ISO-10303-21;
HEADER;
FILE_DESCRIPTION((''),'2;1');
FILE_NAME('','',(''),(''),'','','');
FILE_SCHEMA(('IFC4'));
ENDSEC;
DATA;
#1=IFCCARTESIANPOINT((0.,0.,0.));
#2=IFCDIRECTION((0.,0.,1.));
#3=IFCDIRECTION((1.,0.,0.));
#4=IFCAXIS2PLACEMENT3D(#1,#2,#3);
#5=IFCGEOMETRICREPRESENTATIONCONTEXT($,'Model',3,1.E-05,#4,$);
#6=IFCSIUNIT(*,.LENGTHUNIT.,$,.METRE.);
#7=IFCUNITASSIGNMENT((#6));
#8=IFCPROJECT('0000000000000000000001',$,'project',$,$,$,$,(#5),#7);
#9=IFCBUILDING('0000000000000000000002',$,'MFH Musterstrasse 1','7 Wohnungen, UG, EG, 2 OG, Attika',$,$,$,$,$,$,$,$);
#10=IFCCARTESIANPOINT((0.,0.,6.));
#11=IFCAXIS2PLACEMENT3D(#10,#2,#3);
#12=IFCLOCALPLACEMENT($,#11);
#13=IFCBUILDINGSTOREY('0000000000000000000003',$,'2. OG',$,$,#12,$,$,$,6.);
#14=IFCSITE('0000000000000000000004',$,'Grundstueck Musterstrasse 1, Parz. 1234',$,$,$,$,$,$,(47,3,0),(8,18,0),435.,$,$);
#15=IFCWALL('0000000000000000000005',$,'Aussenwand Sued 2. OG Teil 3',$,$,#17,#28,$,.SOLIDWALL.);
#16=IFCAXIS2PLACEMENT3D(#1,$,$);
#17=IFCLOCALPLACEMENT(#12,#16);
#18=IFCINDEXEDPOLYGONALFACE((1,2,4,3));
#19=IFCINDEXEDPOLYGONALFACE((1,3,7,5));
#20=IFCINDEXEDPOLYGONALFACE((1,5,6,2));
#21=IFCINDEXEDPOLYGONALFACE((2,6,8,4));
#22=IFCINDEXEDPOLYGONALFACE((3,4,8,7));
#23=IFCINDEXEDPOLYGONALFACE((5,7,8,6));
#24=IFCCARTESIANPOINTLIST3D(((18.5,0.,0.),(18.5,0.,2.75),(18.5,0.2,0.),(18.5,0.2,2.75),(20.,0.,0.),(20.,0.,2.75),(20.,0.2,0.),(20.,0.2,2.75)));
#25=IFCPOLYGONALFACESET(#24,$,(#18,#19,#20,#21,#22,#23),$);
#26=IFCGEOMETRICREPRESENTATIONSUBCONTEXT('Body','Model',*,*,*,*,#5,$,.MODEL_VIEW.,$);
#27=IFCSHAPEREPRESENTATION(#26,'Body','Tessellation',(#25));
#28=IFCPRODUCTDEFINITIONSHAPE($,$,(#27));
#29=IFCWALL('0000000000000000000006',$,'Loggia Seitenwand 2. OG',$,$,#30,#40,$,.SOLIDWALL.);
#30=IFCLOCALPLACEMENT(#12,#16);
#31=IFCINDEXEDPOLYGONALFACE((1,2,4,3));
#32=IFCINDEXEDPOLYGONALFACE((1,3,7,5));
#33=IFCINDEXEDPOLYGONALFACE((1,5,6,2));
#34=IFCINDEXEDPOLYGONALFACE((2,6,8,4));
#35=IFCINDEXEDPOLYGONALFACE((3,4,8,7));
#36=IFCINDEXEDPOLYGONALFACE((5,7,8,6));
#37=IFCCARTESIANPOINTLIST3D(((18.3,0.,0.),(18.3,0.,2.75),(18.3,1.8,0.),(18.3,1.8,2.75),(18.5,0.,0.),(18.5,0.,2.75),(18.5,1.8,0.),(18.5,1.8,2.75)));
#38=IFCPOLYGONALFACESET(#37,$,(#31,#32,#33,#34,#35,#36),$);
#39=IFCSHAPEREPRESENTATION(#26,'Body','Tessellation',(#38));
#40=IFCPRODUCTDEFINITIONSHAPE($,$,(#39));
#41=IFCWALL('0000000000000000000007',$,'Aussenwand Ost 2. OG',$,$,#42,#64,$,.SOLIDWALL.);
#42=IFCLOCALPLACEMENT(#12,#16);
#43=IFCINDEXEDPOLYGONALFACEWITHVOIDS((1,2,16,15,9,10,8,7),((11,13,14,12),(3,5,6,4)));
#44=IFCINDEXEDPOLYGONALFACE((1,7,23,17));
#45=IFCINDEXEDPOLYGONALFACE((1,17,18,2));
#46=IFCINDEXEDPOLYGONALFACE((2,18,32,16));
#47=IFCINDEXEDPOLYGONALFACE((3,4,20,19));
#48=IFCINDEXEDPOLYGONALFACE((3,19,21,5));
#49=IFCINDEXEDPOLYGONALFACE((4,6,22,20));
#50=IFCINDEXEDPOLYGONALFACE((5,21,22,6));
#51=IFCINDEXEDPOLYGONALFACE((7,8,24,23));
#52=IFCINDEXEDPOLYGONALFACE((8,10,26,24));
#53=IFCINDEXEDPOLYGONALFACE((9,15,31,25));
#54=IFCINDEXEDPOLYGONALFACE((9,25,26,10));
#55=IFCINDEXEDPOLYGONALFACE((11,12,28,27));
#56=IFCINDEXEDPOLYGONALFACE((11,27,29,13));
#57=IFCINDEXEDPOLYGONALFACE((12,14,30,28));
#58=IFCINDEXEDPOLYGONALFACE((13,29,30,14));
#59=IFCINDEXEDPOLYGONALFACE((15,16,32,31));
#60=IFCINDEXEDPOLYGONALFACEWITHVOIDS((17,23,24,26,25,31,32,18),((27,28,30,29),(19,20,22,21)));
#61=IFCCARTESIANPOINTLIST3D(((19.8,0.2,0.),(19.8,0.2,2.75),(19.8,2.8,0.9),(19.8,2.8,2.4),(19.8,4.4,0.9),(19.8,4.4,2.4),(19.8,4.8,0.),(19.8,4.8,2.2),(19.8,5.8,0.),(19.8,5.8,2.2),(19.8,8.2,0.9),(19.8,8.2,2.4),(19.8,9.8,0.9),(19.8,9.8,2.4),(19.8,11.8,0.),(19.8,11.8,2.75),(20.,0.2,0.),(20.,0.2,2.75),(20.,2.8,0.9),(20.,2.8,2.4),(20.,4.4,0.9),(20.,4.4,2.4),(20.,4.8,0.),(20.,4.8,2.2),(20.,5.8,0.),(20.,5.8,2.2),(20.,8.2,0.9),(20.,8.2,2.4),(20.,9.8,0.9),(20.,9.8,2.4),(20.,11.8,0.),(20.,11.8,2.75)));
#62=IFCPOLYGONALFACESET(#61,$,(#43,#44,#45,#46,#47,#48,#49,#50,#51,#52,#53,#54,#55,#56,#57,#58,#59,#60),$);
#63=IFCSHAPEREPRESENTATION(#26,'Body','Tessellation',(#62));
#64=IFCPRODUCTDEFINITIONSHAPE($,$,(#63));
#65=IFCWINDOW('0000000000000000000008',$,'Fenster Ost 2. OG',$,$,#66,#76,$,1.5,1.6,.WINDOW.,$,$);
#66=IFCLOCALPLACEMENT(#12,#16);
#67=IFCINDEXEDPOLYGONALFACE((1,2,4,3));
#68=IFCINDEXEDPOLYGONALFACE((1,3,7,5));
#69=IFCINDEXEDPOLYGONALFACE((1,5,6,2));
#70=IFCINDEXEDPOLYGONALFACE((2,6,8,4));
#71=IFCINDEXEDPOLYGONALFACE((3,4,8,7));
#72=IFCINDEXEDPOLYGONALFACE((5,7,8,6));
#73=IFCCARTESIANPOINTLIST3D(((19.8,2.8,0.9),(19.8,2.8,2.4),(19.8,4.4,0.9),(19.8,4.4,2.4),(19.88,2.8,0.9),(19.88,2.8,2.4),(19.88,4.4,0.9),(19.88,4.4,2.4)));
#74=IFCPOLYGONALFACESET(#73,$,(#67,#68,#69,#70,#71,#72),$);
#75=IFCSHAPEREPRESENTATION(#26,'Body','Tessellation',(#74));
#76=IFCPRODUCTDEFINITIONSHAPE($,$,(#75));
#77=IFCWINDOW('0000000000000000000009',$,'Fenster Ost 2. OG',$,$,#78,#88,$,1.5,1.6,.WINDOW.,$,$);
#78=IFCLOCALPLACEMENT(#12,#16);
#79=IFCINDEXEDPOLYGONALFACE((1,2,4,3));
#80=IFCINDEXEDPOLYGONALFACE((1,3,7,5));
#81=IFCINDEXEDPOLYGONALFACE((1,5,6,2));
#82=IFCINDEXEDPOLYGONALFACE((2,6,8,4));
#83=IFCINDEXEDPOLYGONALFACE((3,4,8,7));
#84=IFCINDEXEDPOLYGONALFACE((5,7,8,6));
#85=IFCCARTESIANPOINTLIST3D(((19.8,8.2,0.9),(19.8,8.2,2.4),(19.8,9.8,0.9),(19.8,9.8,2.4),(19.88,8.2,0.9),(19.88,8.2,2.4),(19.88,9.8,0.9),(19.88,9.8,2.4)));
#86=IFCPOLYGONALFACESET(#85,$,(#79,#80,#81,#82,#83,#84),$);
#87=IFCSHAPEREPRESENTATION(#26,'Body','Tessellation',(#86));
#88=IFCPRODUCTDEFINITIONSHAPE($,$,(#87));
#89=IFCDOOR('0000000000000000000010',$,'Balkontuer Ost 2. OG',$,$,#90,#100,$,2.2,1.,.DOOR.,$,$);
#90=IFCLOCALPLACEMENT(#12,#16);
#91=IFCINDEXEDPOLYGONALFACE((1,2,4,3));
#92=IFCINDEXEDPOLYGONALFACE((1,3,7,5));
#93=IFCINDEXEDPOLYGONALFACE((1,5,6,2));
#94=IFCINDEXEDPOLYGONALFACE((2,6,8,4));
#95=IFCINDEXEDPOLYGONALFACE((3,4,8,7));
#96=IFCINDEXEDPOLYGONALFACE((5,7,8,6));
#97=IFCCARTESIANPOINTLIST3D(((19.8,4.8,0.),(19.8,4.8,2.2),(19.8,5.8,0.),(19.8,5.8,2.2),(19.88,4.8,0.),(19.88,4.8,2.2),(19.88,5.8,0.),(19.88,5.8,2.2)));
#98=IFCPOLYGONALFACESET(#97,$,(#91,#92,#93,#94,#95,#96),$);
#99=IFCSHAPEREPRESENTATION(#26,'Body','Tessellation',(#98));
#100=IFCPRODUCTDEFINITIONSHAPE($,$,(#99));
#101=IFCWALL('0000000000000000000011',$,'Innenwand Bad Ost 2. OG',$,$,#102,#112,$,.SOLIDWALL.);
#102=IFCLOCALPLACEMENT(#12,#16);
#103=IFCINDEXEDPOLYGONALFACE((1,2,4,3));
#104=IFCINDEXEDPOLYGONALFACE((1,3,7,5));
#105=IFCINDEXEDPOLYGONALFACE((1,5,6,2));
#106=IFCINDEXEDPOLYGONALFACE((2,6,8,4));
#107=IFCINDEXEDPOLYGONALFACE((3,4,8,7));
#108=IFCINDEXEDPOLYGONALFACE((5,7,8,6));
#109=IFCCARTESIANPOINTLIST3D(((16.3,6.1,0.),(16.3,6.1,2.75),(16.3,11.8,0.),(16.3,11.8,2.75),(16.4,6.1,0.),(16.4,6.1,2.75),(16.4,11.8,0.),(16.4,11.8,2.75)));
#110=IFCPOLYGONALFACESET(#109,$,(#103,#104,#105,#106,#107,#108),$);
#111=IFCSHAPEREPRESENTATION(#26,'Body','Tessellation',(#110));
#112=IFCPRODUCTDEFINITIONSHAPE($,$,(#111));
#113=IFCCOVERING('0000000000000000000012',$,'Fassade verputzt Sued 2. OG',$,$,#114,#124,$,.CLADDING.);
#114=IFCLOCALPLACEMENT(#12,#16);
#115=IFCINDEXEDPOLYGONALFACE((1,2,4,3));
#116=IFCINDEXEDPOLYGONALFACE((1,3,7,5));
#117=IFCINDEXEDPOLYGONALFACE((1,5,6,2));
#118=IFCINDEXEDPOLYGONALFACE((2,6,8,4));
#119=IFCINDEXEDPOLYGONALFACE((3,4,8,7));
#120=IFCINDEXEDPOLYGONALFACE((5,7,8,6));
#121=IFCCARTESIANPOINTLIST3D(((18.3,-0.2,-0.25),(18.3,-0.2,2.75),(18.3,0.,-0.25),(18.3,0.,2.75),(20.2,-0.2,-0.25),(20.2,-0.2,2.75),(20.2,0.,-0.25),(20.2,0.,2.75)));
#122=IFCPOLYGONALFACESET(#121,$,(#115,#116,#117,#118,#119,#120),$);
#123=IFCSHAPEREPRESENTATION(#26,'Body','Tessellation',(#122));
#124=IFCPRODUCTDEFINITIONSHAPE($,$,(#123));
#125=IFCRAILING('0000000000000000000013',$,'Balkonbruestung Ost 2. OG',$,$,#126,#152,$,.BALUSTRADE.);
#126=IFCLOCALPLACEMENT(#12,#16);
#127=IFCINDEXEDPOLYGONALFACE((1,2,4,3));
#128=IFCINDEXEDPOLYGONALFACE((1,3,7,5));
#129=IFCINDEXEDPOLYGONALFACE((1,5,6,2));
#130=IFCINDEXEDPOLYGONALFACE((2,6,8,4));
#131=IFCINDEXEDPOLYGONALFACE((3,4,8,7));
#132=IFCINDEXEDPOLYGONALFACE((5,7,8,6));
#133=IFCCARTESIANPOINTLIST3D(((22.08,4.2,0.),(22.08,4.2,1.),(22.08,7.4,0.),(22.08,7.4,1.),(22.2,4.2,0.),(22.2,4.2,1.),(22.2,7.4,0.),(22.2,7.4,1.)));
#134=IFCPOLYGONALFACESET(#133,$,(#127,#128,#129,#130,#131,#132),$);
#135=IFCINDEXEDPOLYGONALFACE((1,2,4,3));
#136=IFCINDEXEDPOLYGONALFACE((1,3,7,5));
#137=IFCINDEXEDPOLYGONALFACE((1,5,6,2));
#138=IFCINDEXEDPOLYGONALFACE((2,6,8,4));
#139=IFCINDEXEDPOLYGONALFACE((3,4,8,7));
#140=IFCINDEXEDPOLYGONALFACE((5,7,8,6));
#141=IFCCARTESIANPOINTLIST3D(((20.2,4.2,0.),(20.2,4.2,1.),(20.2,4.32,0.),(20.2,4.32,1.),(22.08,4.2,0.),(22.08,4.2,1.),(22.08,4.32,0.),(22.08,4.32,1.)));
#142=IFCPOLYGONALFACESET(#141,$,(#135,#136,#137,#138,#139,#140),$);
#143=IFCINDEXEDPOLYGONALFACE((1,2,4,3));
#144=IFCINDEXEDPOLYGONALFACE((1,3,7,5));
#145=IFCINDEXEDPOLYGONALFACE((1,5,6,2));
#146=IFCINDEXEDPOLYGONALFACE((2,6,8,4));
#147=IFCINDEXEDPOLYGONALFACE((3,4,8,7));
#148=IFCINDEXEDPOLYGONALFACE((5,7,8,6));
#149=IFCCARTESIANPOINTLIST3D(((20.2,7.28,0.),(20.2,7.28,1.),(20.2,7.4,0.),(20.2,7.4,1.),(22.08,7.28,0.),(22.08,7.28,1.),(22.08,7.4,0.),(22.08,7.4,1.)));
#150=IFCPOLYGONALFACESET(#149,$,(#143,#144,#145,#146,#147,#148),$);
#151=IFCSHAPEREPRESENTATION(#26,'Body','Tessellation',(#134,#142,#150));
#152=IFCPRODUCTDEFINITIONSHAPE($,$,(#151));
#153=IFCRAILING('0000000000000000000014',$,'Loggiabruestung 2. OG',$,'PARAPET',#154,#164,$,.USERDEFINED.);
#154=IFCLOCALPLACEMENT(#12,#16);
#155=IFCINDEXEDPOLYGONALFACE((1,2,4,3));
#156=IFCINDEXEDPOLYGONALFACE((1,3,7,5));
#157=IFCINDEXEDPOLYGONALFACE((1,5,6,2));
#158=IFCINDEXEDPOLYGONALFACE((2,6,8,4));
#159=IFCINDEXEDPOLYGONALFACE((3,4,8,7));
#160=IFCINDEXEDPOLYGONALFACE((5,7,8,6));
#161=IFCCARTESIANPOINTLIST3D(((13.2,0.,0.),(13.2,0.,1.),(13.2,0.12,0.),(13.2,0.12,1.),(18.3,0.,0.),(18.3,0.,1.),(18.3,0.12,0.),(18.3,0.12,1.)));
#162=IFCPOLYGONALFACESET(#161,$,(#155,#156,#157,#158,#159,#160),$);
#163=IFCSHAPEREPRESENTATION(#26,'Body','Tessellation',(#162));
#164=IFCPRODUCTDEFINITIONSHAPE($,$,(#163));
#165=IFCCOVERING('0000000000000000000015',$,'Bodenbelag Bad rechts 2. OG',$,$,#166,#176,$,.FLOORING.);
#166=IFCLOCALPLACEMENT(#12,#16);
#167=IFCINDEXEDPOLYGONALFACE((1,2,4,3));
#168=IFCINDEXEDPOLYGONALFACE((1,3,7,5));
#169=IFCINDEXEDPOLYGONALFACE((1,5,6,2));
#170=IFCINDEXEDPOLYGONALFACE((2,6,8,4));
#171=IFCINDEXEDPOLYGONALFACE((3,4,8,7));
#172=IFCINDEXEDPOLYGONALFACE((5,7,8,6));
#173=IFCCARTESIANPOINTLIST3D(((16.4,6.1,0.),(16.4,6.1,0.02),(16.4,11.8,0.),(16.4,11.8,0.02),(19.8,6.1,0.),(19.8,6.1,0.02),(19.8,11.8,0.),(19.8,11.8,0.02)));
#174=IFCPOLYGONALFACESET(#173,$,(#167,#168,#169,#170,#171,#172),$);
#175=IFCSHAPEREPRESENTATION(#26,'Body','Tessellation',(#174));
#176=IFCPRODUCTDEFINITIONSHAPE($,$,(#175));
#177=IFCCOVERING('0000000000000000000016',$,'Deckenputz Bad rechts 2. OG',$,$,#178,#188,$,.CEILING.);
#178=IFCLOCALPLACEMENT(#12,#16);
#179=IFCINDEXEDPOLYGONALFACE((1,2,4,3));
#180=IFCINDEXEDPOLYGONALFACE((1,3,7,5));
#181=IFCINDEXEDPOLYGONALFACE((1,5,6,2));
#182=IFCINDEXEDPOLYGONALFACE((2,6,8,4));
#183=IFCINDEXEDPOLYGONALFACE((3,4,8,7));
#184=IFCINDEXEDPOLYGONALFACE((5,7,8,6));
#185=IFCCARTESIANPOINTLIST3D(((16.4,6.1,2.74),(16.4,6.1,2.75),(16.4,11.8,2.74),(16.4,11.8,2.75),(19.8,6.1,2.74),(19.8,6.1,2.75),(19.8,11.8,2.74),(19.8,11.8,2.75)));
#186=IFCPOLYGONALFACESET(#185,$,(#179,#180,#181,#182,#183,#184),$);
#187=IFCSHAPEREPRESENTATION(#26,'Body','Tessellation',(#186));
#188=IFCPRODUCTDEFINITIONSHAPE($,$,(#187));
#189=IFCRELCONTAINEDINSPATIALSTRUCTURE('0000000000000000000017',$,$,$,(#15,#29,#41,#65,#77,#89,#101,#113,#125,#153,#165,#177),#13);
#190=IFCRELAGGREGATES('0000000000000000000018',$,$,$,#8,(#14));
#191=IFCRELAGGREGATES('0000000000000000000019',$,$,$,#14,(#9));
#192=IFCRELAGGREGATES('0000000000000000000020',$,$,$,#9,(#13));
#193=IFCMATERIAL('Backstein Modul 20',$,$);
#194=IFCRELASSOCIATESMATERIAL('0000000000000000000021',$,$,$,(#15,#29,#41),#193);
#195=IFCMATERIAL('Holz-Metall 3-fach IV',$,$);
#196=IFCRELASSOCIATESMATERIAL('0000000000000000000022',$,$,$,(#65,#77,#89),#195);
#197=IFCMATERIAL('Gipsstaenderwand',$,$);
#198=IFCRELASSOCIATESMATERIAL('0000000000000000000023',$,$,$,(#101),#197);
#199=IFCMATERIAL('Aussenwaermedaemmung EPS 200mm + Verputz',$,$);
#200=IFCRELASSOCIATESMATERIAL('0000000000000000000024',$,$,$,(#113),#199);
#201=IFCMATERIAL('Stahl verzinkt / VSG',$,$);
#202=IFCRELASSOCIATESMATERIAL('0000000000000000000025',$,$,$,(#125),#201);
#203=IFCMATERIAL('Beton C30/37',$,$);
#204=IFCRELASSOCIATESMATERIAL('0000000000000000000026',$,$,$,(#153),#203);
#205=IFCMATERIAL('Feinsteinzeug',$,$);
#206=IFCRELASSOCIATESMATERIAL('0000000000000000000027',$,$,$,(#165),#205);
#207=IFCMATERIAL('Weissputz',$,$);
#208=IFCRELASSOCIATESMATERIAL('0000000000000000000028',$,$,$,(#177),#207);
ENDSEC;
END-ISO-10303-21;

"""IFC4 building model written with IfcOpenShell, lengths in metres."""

from ifc_helpers import new_model, si_unit, frame, frame_2d, origin_with_axes, place, context, subcontext, project, spatial, rectangle, extrude, material, element, fill, save


model = new_model("IFC4")

# Units and contexts
model_context = context("Model", 3, precision=1e-05, world=origin_with_axes())
body_context = subcontext(model_context, "Body", "Model", "MODEL_VIEW")
ifc_project = project(units=[si_unit("LENGTHUNIT", "METRE")], contexts=[model_context])

# Site, building, storey
site = spatial("IfcSite", under=ifc_project, Name="Grundstueck Musterstrasse 1, Parz. 1234", RefLatitude=(47, 3, 0), RefLongitude=(8, 18, 0), RefElevation=435.0)
building = spatial("IfcBuilding", under=site, Name="MFH Musterstrasse 1", Description="7 Wohnungen, UG, EG, 2 OG, Attika")
storey_placement = place(None, frame((0.0, 0.0, 6.0), z_axis=(0.0, 0.0, 1.0), x_axis=(1.0, 0.0, 0.0)))
storey = spatial("IfcBuildingStorey", under=building, at=storey_placement, Name="2. OG", Elevation=6.0)

# Walls
ifc_material_1 = material(Name="Backstein Modul 20")
wall_1_placement = place(storey_placement, frame((18.5, 0.0, 0.0), z_axis=(0.0, 0.0, 1.0), x_axis=(1.0, 0.0, 0.0)))
element("IfcWall", 1, at=wall_1_placement, inside=storey, material=ifc_material_1, Name="Aussenwand Sued 2. OG Teil 3", PredefinedType="SOLIDWALL", context=body_context, shape_type="SweptSolid", body=[
    extrude(rectangle(XDim=1.5, YDim=0.2, at=frame_2d((0.75, 0.1))), origin_with_axes(), (0.0, 0.0, 1.0), 2.75),
])
wall_2_placement = place(storey_placement, frame((18.3, 0.2, 0.0), z_axis=(0.0, 0.0, 1.0), x_axis=(1.0, 0.0, 0.0)))
element("IfcWall", 2, at=wall_2_placement, inside=storey, material=ifc_material_1, Name="Loggia Seitenwand 2. OG", PredefinedType="SOLIDWALL", context=body_context, shape_type="SweptSolid", body=[
    extrude(rectangle(XDim=0.2, YDim=1.8, at=frame_2d((0.1, 0.7))), origin_with_axes(), (0.0, 0.0, 1.0), 2.75),
])

# Wall, openings, windows, door
wall_3_placement = place(storey_placement, frame((19.8, 0.2, 0.0), z_axis=(0.0, 0.0, 1.0), x_axis=(1.0, 0.0, 0.0)))
wall_3 = element("IfcWall", 3, at=wall_3_placement, inside=storey, material=ifc_material_1, Name="Aussenwand Ost 2. OG", PredefinedType="SOLIDWALL", context=body_context, shape_type="SweptSolid", body=[
    extrude(rectangle(XDim=0.2, YDim=11.6, at=frame_2d((0.1, 5.8))), origin_with_axes(), (0.0, 0.0, 1.0), 2.75),
])
opening_1_placement = place(wall_3_placement, frame((-0.01, 2.6, 0.9), z_axis=(0.0, 0.0, 1.0), x_axis=(1.0, 0.0, 0.0)))
opening_1 = element("IfcOpeningElement", 4, at=opening_1_placement, cuts=wall_3, context=body_context, shape_type="SweptSolid", body=[
    extrude(rectangle(XDim=0.42, YDim=1.6, at=frame_2d((0.21, 0.8))), origin_with_axes(), (0.0, 0.0, 1.0), 1.5),
])
opening_2_placement = place(wall_3_placement, frame((-0.01, 8.0, 0.9), z_axis=(0.0, 0.0, 1.0), x_axis=(1.0, 0.0, 0.0)))
opening_2 = element("IfcOpeningElement", 5, at=opening_2_placement, cuts=wall_3, context=body_context, shape_type="SweptSolid", body=[
    extrude(rectangle(XDim=0.42, YDim=1.6, at=frame_2d((0.21, 0.8))), origin_with_axes(), (0.0, 0.0, 1.0), 1.5),
])
opening_3_placement = place(wall_3_placement, frame((-0.01, 4.6, 0.0), z_axis=(0.0, 0.0, 1.0), x_axis=(1.0, 0.0, 0.0)))
opening_3 = element("IfcOpeningElement", 6, at=opening_3_placement, cuts=wall_3, context=body_context, shape_type="SweptSolid", body=[
    extrude(rectangle(XDim=0.42, YDim=1.0, at=frame_2d((0.21, 0.5))), origin_with_axes(), (0.0, 0.0, 1.0), 2.2),
])
ifc_material_2 = material(Name="Holz-Metall 3-fach IV")
window_1_placement = place(storey_placement, frame((19.8, 2.8, 0.9), z_axis=(0.0, 0.0, 1.0), x_axis=(1.0, 0.0, 0.0)))
window_1 = element("IfcWindow", 7, at=window_1_placement, inside=storey, material=ifc_material_2, Name="Fenster Ost 2. OG", OverallHeight=1.5, OverallWidth=1.6, PredefinedType="WINDOW", context=body_context, shape_type="SweptSolid", body=[
    extrude(rectangle(XDim=0.08, YDim=1.6, at=frame_2d((0.04, 0.8))), origin_with_axes(), (0.0, 0.0, 1.0), 1.5),
])
fill(opening_1, window_1)
window_2_placement = place(storey_placement, frame((19.8, 8.2, 0.9), z_axis=(0.0, 0.0, 1.0), x_axis=(1.0, 0.0, 0.0)))
window_2 = element("IfcWindow", 8, at=window_2_placement, inside=storey, material=ifc_material_2, Name="Fenster Ost 2. OG", OverallHeight=1.5, OverallWidth=1.6, PredefinedType="WINDOW", context=body_context, shape_type="SweptSolid", body=[
    extrude(rectangle(XDim=0.08, YDim=1.6, at=frame_2d((0.04, 0.8))), origin_with_axes(), (0.0, 0.0, 1.0), 1.5),
])
fill(opening_2, window_2)
door_placement = place(storey_placement, frame((19.8, 4.8, 0.0), z_axis=(0.0, 0.0, 1.0), x_axis=(1.0, 0.0, 0.0)))
door = element("IfcDoor", 9, at=door_placement, inside=storey, material=ifc_material_2, Name="Balkontuer Ost 2. OG", OverallHeight=2.2, OverallWidth=1.0, PredefinedType="DOOR", context=body_context, shape_type="SweptSolid", body=[
    extrude(rectangle(XDim=0.08, YDim=1.0, at=frame_2d((0.04, 0.5))), origin_with_axes(), (0.0, 0.0, 1.0), 2.2),
])
fill(opening_3, door)

# Wall
ifc_material_3 = material(Name="Gipsstaenderwand")
wall_4_placement = place(storey_placement, frame((16.3, 6.1, 0.0), z_axis=(0.0, 0.0, 1.0), x_axis=(1.0, 0.0, 0.0)))
element("IfcWall", 10, at=wall_4_placement, inside=storey, material=ifc_material_3, Name="Innenwand Bad Ost 2. OG", PredefinedType="SOLIDWALL", context=body_context, shape_type="SweptSolid", body=[
    extrude(rectangle(XDim=0.1, YDim=5.7, at=frame_2d((0.05, 2.85))), origin_with_axes(), (0.0, 0.0, 1.0), 2.75),
])

# Shared definitions
ifc_material_4 = material(Name="Aussenwaermedaemmung EPS 200mm + Verputz")

# Covering
covering_1_placement = place(storey_placement, frame((18.5, -0.2, -0.25), z_axis=(0.0, 0.0, 1.0), x_axis=(1.0, 0.0, 0.0)))
element("IfcCovering", 11, at=covering_1_placement, inside=storey, material=ifc_material_4, Name="Fassade verputzt Sued 2. OG", PredefinedType="CLADDING", context=body_context, shape_type="SweptSolid", body=[
    extrude(rectangle(XDim=1.9, YDim=0.2, at=frame_2d((0.75, 0.1))), origin_with_axes(), (0.0, 0.0, 1.0), 3.0),
])

# Railings
ifc_material_5 = material(Name="Stahl verzinkt / VSG")
railing_1_placement = place(storey_placement, frame((22.08, 4.2, 0.0), z_axis=(0.0, 0.0, 1.0), x_axis=(1.0, 0.0, 0.0)))
element("IfcRailing", 12, at=railing_1_placement, inside=storey, material=ifc_material_5, Name="Balkonbruestung Ost 2. OG", PredefinedType="BALUSTRADE", context=body_context, shape_type="SweptSolid", body=[
    extrude(rectangle(XDim=0.12, YDim=3.2, at=frame_2d((0.06, 1.6))), origin_with_axes(), (0.0, 0.0, 1.0), 1.0),
    extrude(rectangle(XDim=1.88, YDim=0.12, at=frame_2d((-0.94, 0.06))), origin_with_axes(), (0.0, 0.0, 1.0), 1.0),
    extrude(rectangle(XDim=1.88, YDim=0.12, at=frame_2d((-0.94, 3.14))), origin_with_axes(), (0.0, 0.0, 1.0), 1.0),
])
ifc_material_6 = material(Name="Beton C30/37")
railing_2_placement = place(storey_placement, frame((13.2, 0.0, 0.0), z_axis=(0.0, 0.0, 1.0), x_axis=(1.0, 0.0, 0.0)))
element("IfcRailing", 13, at=railing_2_placement, inside=storey, material=ifc_material_6, Name="Loggiabruestung 2. OG", ObjectType="PARAPET", PredefinedType="USERDEFINED", context=body_context, shape_type="SweptSolid", body=[
    extrude(rectangle(XDim=5.1, YDim=0.12, at=frame_2d((2.55, 0.06))), origin_with_axes(), (0.0, 0.0, 1.0), 1.0),
])

# Coverings
ifc_material_7 = material(Name="Feinsteinzeug")
covering_2_placement = place(storey_placement, frame((16.4, 6.1, 0.0), z_axis=(0.0, 0.0, 1.0), x_axis=(1.0, 0.0, 0.0)))
element("IfcCovering", 14, at=covering_2_placement, inside=storey, material=ifc_material_7, Name="Bodenbelag Bad rechts 2. OG", PredefinedType="FLOORING", context=body_context, shape_type="SweptSolid", body=[
    extrude(rectangle(XDim=3.4, YDim=5.7, at=frame_2d((1.7, 2.85))), origin_with_axes(), (0.0, 0.0, 1.0), 0.02),
])
ifc_material_8 = material(Name="Weissputz")
covering_3_placement = place(storey_placement, frame((16.4, 6.1, 2.74), z_axis=(0.0, 0.0, 1.0), x_axis=(1.0, 0.0, 0.0)))
element("IfcCovering", 15, at=covering_3_placement, inside=storey, material=ifc_material_8, Name="Deckenputz Bad rechts 2. OG", PredefinedType="CEILING", context=body_context, shape_type="SweptSolid", body=[
    extrude(rectangle(XDim=3.4, YDim=5.7, at=frame_2d((1.7, 2.85))), origin_with_axes(), (0.0, 0.0, 1.0), 0.01),
])

save(model, "model.ifc")
